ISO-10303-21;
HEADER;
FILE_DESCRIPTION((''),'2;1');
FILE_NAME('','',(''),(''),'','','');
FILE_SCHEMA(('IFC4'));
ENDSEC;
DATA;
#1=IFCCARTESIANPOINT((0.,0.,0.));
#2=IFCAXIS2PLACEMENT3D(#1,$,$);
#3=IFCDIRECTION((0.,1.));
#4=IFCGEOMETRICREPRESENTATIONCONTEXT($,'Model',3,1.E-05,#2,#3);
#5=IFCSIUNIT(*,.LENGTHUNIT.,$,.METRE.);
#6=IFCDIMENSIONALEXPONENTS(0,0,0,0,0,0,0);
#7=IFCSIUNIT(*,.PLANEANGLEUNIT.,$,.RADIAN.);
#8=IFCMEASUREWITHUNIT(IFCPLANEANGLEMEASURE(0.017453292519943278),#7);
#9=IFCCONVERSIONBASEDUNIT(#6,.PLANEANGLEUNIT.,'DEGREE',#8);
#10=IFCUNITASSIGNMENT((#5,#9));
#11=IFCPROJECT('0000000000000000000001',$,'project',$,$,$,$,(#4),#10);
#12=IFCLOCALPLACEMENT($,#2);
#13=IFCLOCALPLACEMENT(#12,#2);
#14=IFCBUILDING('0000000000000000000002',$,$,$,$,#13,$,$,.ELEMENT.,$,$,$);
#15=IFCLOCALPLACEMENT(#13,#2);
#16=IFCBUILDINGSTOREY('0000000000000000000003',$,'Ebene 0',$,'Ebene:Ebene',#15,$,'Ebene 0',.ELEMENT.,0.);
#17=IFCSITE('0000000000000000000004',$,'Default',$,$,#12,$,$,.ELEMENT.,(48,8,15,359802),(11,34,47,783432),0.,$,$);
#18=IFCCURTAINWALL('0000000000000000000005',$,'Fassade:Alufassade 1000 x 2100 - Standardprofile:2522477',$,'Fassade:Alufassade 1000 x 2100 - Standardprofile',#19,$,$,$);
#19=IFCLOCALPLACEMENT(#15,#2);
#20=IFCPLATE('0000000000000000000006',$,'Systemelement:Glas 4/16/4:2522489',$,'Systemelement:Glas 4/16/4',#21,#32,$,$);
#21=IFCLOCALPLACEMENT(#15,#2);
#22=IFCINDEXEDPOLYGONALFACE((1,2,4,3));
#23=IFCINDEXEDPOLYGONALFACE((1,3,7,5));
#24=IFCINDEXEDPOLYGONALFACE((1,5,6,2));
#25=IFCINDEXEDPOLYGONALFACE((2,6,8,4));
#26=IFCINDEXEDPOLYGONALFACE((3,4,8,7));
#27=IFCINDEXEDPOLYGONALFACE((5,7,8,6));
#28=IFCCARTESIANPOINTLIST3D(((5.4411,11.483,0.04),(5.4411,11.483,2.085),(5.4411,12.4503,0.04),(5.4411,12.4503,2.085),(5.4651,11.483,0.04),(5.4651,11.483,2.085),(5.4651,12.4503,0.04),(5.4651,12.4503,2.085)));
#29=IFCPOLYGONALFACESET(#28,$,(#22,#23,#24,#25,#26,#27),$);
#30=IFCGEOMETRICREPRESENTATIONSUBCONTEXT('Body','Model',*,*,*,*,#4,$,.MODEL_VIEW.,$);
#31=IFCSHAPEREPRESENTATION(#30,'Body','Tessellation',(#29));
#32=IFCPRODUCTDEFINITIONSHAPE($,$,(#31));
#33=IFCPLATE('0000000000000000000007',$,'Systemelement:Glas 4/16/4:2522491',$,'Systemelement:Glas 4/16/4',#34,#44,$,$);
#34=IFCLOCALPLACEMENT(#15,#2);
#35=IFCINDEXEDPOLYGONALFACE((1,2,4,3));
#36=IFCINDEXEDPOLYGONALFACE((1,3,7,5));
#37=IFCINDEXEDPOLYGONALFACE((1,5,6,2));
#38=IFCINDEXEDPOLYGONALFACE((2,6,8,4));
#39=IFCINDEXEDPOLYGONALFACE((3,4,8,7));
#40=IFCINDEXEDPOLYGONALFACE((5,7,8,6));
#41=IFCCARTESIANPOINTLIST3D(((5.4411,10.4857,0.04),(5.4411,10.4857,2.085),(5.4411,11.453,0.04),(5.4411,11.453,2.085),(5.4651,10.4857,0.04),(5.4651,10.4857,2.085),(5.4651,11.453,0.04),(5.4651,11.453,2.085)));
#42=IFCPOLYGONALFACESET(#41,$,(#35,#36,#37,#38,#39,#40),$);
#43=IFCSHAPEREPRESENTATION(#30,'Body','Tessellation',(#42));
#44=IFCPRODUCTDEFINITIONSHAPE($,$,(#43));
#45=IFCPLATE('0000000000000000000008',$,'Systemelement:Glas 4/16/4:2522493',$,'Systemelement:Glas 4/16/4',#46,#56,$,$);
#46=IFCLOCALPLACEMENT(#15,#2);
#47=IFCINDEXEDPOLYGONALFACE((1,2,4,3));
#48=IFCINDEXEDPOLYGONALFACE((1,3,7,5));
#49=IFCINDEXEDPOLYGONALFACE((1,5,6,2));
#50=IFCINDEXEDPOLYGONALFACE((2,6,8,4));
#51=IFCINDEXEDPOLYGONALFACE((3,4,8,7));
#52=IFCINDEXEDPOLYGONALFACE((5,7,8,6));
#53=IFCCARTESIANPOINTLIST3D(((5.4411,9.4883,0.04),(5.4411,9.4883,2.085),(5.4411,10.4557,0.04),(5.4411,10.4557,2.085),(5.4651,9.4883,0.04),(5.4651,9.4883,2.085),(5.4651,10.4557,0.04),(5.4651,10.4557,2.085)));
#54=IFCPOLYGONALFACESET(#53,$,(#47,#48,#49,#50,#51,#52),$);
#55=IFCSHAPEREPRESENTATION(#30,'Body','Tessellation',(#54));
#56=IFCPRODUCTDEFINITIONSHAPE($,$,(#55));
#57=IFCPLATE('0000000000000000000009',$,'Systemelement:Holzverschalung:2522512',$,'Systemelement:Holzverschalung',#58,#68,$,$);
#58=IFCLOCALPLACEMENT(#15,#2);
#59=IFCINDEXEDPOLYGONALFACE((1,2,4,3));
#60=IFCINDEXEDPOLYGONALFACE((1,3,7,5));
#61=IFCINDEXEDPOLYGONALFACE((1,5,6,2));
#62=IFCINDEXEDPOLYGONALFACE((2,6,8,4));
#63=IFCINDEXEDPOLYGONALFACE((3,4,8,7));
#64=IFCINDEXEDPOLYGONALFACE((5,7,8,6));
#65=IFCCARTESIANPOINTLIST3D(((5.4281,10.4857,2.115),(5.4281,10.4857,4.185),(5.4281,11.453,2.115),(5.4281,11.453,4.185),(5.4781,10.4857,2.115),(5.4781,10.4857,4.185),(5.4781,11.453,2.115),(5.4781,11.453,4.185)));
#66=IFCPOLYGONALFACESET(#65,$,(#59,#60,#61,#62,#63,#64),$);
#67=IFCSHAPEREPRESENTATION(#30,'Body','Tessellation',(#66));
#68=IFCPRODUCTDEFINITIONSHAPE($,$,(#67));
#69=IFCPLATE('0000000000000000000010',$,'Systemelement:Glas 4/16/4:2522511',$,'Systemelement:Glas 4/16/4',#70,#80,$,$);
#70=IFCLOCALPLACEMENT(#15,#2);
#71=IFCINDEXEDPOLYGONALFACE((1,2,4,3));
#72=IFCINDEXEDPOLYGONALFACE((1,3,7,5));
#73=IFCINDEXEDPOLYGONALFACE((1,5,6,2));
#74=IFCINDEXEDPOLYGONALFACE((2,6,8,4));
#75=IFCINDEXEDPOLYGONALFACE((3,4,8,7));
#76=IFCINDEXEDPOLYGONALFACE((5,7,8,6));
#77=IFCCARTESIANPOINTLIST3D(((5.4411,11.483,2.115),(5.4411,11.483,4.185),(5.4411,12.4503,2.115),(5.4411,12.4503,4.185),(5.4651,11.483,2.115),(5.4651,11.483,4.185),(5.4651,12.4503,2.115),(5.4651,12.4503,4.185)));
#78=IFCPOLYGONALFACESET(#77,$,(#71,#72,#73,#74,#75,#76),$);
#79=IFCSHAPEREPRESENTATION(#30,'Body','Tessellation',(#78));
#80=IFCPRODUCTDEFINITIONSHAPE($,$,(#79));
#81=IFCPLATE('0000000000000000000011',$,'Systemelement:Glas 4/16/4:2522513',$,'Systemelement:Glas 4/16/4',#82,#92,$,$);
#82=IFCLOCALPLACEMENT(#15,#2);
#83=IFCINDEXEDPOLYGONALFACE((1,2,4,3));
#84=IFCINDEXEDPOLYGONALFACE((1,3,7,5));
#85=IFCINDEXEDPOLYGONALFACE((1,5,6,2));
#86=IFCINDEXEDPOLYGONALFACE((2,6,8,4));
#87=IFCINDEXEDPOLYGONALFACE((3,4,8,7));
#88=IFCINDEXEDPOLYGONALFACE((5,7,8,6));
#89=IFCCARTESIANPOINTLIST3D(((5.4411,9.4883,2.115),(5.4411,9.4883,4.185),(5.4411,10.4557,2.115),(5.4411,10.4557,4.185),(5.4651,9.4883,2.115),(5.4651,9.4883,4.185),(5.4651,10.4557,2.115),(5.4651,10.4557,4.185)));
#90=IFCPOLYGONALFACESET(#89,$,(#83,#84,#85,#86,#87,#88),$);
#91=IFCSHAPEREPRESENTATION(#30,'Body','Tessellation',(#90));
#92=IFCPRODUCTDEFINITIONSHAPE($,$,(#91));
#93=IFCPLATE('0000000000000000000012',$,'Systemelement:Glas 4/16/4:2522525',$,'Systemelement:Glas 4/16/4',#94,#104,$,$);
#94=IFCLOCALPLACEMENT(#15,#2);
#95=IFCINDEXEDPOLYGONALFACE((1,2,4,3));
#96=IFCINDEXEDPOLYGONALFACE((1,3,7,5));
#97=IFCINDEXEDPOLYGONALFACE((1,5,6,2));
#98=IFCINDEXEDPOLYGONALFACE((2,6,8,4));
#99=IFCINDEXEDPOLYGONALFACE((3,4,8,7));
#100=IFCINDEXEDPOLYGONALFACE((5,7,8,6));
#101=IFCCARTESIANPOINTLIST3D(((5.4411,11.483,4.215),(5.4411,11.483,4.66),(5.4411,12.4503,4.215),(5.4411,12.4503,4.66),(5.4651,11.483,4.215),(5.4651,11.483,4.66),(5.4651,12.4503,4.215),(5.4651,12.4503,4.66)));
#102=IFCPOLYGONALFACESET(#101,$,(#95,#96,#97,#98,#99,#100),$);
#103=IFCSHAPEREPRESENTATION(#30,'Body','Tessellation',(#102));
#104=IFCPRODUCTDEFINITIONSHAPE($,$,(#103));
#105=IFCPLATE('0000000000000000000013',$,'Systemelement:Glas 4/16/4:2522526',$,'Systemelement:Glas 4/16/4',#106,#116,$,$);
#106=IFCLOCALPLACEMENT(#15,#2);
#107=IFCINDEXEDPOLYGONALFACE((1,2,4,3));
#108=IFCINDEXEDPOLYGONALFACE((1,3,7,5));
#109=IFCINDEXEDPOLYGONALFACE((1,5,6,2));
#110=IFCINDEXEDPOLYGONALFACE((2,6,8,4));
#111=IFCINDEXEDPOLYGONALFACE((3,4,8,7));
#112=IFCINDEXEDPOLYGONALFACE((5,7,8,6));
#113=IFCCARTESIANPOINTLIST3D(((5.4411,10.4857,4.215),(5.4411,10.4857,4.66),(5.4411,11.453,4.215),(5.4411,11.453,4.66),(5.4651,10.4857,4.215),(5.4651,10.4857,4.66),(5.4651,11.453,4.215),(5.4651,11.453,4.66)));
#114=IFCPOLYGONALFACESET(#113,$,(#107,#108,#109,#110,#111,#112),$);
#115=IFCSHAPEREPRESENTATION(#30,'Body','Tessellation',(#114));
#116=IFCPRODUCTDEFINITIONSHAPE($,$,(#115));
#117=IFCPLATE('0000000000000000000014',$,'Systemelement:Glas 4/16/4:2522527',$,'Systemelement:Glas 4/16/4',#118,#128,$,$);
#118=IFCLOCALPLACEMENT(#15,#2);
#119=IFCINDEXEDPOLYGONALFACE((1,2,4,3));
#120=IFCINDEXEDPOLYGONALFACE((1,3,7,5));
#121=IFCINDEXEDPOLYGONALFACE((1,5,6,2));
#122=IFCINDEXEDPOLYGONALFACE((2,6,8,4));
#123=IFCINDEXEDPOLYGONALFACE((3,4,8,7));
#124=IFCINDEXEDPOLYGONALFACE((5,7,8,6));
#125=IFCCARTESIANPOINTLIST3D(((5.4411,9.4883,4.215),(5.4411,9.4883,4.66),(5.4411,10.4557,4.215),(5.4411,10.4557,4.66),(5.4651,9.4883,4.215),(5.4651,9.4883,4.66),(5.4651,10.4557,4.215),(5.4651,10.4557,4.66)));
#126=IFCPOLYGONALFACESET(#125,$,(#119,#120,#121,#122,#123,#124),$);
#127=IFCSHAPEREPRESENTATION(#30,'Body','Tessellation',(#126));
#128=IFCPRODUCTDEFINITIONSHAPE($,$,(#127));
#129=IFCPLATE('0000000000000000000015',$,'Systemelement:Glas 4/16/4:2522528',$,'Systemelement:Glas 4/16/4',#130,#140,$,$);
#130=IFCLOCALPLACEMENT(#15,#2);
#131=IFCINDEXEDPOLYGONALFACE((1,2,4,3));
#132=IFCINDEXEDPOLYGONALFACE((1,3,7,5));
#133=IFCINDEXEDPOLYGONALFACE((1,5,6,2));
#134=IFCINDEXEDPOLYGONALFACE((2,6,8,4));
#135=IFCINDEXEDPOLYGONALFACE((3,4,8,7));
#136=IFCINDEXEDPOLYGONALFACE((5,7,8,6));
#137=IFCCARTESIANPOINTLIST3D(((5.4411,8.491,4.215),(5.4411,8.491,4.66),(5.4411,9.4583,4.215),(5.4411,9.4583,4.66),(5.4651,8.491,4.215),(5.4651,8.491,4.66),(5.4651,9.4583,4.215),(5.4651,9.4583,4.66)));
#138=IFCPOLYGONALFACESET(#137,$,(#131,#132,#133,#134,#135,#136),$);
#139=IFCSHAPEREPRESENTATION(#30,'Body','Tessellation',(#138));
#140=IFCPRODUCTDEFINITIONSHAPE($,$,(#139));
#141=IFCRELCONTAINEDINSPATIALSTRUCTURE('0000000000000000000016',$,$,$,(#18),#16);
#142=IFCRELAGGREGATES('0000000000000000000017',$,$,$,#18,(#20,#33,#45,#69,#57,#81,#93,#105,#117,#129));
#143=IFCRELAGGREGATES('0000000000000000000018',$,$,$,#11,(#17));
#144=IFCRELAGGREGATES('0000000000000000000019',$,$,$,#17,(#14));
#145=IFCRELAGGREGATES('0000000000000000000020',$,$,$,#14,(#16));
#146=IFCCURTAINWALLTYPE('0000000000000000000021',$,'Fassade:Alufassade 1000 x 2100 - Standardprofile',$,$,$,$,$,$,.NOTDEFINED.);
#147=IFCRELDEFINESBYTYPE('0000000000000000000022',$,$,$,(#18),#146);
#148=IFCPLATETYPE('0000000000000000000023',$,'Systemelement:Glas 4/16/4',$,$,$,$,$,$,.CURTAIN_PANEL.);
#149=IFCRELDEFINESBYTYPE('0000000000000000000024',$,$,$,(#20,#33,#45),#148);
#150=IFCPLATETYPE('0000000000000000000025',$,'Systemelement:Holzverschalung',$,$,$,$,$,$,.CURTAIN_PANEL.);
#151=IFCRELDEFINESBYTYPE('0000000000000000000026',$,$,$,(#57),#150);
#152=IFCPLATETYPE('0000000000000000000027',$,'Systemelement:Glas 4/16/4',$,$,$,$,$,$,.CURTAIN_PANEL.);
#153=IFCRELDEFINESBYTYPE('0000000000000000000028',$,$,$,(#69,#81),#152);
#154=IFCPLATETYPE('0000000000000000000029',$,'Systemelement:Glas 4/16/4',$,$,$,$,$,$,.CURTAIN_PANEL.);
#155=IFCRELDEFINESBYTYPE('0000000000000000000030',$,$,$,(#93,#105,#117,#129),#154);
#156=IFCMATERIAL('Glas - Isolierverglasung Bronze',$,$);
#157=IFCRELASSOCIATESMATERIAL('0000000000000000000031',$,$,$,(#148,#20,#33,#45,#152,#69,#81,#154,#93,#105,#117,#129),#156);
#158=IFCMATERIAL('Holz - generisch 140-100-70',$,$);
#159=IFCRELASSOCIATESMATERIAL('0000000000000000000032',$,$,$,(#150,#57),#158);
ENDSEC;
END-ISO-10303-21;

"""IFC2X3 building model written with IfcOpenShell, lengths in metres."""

from ifc_helpers import new_model, entity, si_unit, converted_unit, direction, frame, origin, origin_2d_with_axis, place, context, subcontext, project, spatial, rectangle, extrude, source, transform, mapped, material, type_object, type_shapes, element, aggregate, save


model = new_model("IFC2X3")

# Units and contexts
model_context = context("Model", 3, precision=1e-05, world=origin(), true_north=direction((0.0, 1.0)))
body_context = subcontext(model_context, "Body", "Model", "MODEL_VIEW")
ifc_project = project(units=[si_unit("LENGTHUNIT", "METRE"), converted_unit("PLANEANGLEUNIT", "DEGREE", entity("IfcPlaneAngleMeasure", 0.017453292519943278), si_unit("PLANEANGLEUNIT", "RADIAN"), dimensions=[0, 0, 0, 0, 0, 0, 0])], contexts=[model_context])

# Site, building, storey
site_placement = place(None, origin())
site = spatial("IfcSite", under=ifc_project, at=site_placement, Name="Default", CompositionType="ELEMENT", RefLatitude=(48, 8, 15, 359802), RefLongitude=(11, 34, 47, 783432), RefElevation=0.0)
building_placement = place(site_placement, origin())
building = spatial("IfcBuilding", under=site, at=building_placement, CompositionType="ELEMENT")
storey_placement = place(building_placement, origin())
storey = spatial("IfcBuildingStorey", under=building, at=storey_placement, Name="Ebene 0", ObjectType="Ebene:Ebene", LongName="Ebene 0", CompositionType="ELEMENT", Elevation=0.0)

# Curtain wall, plates
curtain_wall_type = type_object("IfcCurtainWallType", Name="Fassade:Alufassade 1000 x 2100 - Standardprofile", PredefinedType="NOTDEFINED")
curtain_wall_placement = place(storey_placement, origin())
curtain_wall = element("IfcCurtainWall", 1, at=curtain_wall_placement, inside=storey, type_object=curtain_wall_type, Name="Fassade:Alufassade 1000 x 2100 - Standardprofile:2522477", ObjectType="Fassade:Alufassade 1000 x 2100 - Standardprofile")
ifc_material_1 = material(Name="Glas - Isolierverglasung Bronze")
plate_type_1 = type_object("IfcPlateType", Name="Systemelement:Glas 4/16/4", PredefinedType="CURTAIN_PANEL", material=ifc_material_1)
shared_shape_1 = source(origin(), body_context, "Body", "SweptSolid", [
    extrude(rectangle(XDim=0.024, YDim=0.9673, at=origin_2d_with_axis()), frame((0.0, 0.0, 0.0), z_axis=(0.0, 0.0, 1.0), x_axis=(0.0, 1.0, 0.0)), (0.0, 0.0, 1.0), 2.045),
])
type_shapes(plate_type_1, [shared_shape_1])
plate_1_placement = place(curtain_wall_placement, frame((5.4531, 11.9666, 0.04), z_axis=(0.0, 0.0, 1.0), x_axis=(0.0, -1.0, 0.0)))
plate_1 = element("IfcPlate", 2, at=plate_1_placement, type_object=plate_type_1, material=ifc_material_1, Name="Systemelement:Glas 4/16/4:2522489", ObjectType="Systemelement:Glas 4/16/4", context=body_context, shape_type="MappedRepresentation", body=[
    mapped(shared_shape_1, transform((0.0, 0.0, 0.0), scale=1.0)),
])
plate_2_placement = place(curtain_wall_placement, frame((5.4531, 10.9693, 0.04), z_axis=(0.0, 0.0, 1.0), x_axis=(0.0, -1.0, 0.0)))
plate_2 = element("IfcPlate", 3, at=plate_2_placement, type_object=plate_type_1, material=ifc_material_1, Name="Systemelement:Glas 4/16/4:2522491", ObjectType="Systemelement:Glas 4/16/4", context=body_context, shape_type="MappedRepresentation", body=[
    mapped(shared_shape_1, transform((0.0, 0.0, 0.0), scale=1.0)),
])
plate_3_placement = place(curtain_wall_placement, frame((5.4531, 9.972, 0.04), z_axis=(0.0, 0.0, 1.0), x_axis=(0.0, -1.0, 0.0)))
plate_3 = element("IfcPlate", 4, at=plate_3_placement, type_object=plate_type_1, material=ifc_material_1, Name="Systemelement:Glas 4/16/4:2522493", ObjectType="Systemelement:Glas 4/16/4", context=body_context, shape_type="MappedRepresentation", body=[
    mapped(shared_shape_1, transform((0.0, 0.0, 0.0), scale=1.0)),
])
ifc_material_2 = material(Name="Holz - generisch 140-100-70")
plate_type_2 = type_object("IfcPlateType", Name="Systemelement:Holzverschalung", PredefinedType="CURTAIN_PANEL", material=ifc_material_2)
shared_shape_2 = source(origin(), body_context, "Body", "SweptSolid", [
    extrude(rectangle(XDim=0.05, YDim=0.9673, at=origin_2d_with_axis()), frame((0.0, 0.0, 0.0), z_axis=(0.0, 0.0, 1.0), x_axis=(0.0, 1.0, 0.0)), (0.0, 0.0, 1.0), 2.07),
])
type_shapes(plate_type_2, [shared_shape_2])
plate_4_placement = place(curtain_wall_placement, frame((5.4531, 10.9693, 2.115), z_axis=(0.0, 0.0, 1.0), x_axis=(0.0, -1.0, 0.0)))
plate_4 = element("IfcPlate", 5, at=plate_4_placement, type_object=plate_type_2, material=ifc_material_2, Name="Systemelement:Holzverschalung:2522512", ObjectType="Systemelement:Holzverschalung", context=body_context, shape_type="MappedRepresentation", body=[
    mapped(shared_shape_2, transform((0.0, 0.0, 0.0), scale=1.0)),
])
plate_type_3 = type_object("IfcPlateType", Name="Systemelement:Glas 4/16/4", PredefinedType="CURTAIN_PANEL", material=ifc_material_1)
shared_shape_3 = source(origin(), body_context, "Body", "SweptSolid", [
    extrude(rectangle(XDim=0.024, YDim=0.9673, at=origin_2d_with_axis()), frame((0.0, 0.0, 0.0), z_axis=(0.0, 0.0, 1.0), x_axis=(0.0, 1.0, 0.0)), (0.0, 0.0, 1.0), 2.07),
])
type_shapes(plate_type_3, [shared_shape_3])
plate_5_placement = place(curtain_wall_placement, frame((5.4531, 11.9666, 2.115), z_axis=(0.0, 0.0, 1.0), x_axis=(0.0, -1.0, 0.0)))
plate_5 = element("IfcPlate", 6, at=plate_5_placement, type_object=plate_type_3, material=ifc_material_1, Name="Systemelement:Glas 4/16/4:2522511", ObjectType="Systemelement:Glas 4/16/4", context=body_context, shape_type="MappedRepresentation", body=[
    mapped(shared_shape_3, transform((0.0, 0.0, 0.0), scale=1.0)),
])
plate_6_placement = place(curtain_wall_placement, frame((5.4531, 9.972, 2.115), z_axis=(0.0, 0.0, 1.0), x_axis=(0.0, -1.0, 0.0)))
plate_6 = element("IfcPlate", 7, at=plate_6_placement, type_object=plate_type_3, material=ifc_material_1, Name="Systemelement:Glas 4/16/4:2522513", ObjectType="Systemelement:Glas 4/16/4", context=body_context, shape_type="MappedRepresentation", body=[
    mapped(shared_shape_3, transform((0.0, 0.0, 0.0), scale=1.0)),
])
plate_type_4 = type_object("IfcPlateType", Name="Systemelement:Glas 4/16/4", PredefinedType="CURTAIN_PANEL", material=ifc_material_1)
shared_shape_4 = source(origin(), body_context, "Body", "SweptSolid", [
    extrude(rectangle(XDim=0.024, YDim=0.9673, at=origin_2d_with_axis()), frame((0.0, 0.0, 0.0), z_axis=(0.0, 0.0, 1.0), x_axis=(0.0, 1.0, 0.0)), (0.0, 0.0, 1.0), 0.445),
])
type_shapes(plate_type_4, [shared_shape_4])
plate_7_placement = place(curtain_wall_placement, frame((5.4531, 11.9666, 4.215), z_axis=(0.0, 0.0, 1.0), x_axis=(0.0, -1.0, 0.0)))
plate_7 = element("IfcPlate", 8, at=plate_7_placement, type_object=plate_type_4, material=ifc_material_1, Name="Systemelement:Glas 4/16/4:2522525", ObjectType="Systemelement:Glas 4/16/4", context=body_context, shape_type="MappedRepresentation", body=[
    mapped(shared_shape_4, transform((0.0, 0.0, 0.0), scale=1.0)),
])
plate_8_placement = place(curtain_wall_placement, frame((5.4531, 10.9693, 4.215), z_axis=(0.0, 0.0, 1.0), x_axis=(0.0, -1.0, 0.0)))
plate_8 = element("IfcPlate", 9, at=plate_8_placement, type_object=plate_type_4, material=ifc_material_1, Name="Systemelement:Glas 4/16/4:2522526", ObjectType="Systemelement:Glas 4/16/4", context=body_context, shape_type="MappedRepresentation", body=[
    mapped(shared_shape_4, transform((0.0, 0.0, 0.0), scale=1.0)),
])
plate_9_placement = place(curtain_wall_placement, frame((5.4531, 9.972, 4.215), z_axis=(0.0, 0.0, 1.0), x_axis=(0.0, -1.0, 0.0)))
plate_9 = element("IfcPlate", 10, at=plate_9_placement, type_object=plate_type_4, material=ifc_material_1, Name="Systemelement:Glas 4/16/4:2522527", ObjectType="Systemelement:Glas 4/16/4", context=body_context, shape_type="MappedRepresentation", body=[
    mapped(shared_shape_4, transform((0.0, 0.0, 0.0), scale=1.0)),
])
plate_10_placement = place(curtain_wall_placement, frame((5.4531, 8.9747, 4.215), z_axis=(0.0, 0.0, 1.0), x_axis=(0.0, -1.0, 0.0)))
plate_10 = element("IfcPlate", 11, at=plate_10_placement, type_object=plate_type_4, material=ifc_material_1, Name="Systemelement:Glas 4/16/4:2522528", ObjectType="Systemelement:Glas 4/16/4", context=body_context, shape_type="MappedRepresentation", body=[
    mapped(shared_shape_4, transform((0.0, 0.0, 0.0), scale=1.0)),
])
aggregate(curtain_wall, [plate_1, plate_2, plate_3, plate_5, plate_4, plate_6, plate_7, plate_8, plate_9, plate_10])

save(model, "model.ifc")
